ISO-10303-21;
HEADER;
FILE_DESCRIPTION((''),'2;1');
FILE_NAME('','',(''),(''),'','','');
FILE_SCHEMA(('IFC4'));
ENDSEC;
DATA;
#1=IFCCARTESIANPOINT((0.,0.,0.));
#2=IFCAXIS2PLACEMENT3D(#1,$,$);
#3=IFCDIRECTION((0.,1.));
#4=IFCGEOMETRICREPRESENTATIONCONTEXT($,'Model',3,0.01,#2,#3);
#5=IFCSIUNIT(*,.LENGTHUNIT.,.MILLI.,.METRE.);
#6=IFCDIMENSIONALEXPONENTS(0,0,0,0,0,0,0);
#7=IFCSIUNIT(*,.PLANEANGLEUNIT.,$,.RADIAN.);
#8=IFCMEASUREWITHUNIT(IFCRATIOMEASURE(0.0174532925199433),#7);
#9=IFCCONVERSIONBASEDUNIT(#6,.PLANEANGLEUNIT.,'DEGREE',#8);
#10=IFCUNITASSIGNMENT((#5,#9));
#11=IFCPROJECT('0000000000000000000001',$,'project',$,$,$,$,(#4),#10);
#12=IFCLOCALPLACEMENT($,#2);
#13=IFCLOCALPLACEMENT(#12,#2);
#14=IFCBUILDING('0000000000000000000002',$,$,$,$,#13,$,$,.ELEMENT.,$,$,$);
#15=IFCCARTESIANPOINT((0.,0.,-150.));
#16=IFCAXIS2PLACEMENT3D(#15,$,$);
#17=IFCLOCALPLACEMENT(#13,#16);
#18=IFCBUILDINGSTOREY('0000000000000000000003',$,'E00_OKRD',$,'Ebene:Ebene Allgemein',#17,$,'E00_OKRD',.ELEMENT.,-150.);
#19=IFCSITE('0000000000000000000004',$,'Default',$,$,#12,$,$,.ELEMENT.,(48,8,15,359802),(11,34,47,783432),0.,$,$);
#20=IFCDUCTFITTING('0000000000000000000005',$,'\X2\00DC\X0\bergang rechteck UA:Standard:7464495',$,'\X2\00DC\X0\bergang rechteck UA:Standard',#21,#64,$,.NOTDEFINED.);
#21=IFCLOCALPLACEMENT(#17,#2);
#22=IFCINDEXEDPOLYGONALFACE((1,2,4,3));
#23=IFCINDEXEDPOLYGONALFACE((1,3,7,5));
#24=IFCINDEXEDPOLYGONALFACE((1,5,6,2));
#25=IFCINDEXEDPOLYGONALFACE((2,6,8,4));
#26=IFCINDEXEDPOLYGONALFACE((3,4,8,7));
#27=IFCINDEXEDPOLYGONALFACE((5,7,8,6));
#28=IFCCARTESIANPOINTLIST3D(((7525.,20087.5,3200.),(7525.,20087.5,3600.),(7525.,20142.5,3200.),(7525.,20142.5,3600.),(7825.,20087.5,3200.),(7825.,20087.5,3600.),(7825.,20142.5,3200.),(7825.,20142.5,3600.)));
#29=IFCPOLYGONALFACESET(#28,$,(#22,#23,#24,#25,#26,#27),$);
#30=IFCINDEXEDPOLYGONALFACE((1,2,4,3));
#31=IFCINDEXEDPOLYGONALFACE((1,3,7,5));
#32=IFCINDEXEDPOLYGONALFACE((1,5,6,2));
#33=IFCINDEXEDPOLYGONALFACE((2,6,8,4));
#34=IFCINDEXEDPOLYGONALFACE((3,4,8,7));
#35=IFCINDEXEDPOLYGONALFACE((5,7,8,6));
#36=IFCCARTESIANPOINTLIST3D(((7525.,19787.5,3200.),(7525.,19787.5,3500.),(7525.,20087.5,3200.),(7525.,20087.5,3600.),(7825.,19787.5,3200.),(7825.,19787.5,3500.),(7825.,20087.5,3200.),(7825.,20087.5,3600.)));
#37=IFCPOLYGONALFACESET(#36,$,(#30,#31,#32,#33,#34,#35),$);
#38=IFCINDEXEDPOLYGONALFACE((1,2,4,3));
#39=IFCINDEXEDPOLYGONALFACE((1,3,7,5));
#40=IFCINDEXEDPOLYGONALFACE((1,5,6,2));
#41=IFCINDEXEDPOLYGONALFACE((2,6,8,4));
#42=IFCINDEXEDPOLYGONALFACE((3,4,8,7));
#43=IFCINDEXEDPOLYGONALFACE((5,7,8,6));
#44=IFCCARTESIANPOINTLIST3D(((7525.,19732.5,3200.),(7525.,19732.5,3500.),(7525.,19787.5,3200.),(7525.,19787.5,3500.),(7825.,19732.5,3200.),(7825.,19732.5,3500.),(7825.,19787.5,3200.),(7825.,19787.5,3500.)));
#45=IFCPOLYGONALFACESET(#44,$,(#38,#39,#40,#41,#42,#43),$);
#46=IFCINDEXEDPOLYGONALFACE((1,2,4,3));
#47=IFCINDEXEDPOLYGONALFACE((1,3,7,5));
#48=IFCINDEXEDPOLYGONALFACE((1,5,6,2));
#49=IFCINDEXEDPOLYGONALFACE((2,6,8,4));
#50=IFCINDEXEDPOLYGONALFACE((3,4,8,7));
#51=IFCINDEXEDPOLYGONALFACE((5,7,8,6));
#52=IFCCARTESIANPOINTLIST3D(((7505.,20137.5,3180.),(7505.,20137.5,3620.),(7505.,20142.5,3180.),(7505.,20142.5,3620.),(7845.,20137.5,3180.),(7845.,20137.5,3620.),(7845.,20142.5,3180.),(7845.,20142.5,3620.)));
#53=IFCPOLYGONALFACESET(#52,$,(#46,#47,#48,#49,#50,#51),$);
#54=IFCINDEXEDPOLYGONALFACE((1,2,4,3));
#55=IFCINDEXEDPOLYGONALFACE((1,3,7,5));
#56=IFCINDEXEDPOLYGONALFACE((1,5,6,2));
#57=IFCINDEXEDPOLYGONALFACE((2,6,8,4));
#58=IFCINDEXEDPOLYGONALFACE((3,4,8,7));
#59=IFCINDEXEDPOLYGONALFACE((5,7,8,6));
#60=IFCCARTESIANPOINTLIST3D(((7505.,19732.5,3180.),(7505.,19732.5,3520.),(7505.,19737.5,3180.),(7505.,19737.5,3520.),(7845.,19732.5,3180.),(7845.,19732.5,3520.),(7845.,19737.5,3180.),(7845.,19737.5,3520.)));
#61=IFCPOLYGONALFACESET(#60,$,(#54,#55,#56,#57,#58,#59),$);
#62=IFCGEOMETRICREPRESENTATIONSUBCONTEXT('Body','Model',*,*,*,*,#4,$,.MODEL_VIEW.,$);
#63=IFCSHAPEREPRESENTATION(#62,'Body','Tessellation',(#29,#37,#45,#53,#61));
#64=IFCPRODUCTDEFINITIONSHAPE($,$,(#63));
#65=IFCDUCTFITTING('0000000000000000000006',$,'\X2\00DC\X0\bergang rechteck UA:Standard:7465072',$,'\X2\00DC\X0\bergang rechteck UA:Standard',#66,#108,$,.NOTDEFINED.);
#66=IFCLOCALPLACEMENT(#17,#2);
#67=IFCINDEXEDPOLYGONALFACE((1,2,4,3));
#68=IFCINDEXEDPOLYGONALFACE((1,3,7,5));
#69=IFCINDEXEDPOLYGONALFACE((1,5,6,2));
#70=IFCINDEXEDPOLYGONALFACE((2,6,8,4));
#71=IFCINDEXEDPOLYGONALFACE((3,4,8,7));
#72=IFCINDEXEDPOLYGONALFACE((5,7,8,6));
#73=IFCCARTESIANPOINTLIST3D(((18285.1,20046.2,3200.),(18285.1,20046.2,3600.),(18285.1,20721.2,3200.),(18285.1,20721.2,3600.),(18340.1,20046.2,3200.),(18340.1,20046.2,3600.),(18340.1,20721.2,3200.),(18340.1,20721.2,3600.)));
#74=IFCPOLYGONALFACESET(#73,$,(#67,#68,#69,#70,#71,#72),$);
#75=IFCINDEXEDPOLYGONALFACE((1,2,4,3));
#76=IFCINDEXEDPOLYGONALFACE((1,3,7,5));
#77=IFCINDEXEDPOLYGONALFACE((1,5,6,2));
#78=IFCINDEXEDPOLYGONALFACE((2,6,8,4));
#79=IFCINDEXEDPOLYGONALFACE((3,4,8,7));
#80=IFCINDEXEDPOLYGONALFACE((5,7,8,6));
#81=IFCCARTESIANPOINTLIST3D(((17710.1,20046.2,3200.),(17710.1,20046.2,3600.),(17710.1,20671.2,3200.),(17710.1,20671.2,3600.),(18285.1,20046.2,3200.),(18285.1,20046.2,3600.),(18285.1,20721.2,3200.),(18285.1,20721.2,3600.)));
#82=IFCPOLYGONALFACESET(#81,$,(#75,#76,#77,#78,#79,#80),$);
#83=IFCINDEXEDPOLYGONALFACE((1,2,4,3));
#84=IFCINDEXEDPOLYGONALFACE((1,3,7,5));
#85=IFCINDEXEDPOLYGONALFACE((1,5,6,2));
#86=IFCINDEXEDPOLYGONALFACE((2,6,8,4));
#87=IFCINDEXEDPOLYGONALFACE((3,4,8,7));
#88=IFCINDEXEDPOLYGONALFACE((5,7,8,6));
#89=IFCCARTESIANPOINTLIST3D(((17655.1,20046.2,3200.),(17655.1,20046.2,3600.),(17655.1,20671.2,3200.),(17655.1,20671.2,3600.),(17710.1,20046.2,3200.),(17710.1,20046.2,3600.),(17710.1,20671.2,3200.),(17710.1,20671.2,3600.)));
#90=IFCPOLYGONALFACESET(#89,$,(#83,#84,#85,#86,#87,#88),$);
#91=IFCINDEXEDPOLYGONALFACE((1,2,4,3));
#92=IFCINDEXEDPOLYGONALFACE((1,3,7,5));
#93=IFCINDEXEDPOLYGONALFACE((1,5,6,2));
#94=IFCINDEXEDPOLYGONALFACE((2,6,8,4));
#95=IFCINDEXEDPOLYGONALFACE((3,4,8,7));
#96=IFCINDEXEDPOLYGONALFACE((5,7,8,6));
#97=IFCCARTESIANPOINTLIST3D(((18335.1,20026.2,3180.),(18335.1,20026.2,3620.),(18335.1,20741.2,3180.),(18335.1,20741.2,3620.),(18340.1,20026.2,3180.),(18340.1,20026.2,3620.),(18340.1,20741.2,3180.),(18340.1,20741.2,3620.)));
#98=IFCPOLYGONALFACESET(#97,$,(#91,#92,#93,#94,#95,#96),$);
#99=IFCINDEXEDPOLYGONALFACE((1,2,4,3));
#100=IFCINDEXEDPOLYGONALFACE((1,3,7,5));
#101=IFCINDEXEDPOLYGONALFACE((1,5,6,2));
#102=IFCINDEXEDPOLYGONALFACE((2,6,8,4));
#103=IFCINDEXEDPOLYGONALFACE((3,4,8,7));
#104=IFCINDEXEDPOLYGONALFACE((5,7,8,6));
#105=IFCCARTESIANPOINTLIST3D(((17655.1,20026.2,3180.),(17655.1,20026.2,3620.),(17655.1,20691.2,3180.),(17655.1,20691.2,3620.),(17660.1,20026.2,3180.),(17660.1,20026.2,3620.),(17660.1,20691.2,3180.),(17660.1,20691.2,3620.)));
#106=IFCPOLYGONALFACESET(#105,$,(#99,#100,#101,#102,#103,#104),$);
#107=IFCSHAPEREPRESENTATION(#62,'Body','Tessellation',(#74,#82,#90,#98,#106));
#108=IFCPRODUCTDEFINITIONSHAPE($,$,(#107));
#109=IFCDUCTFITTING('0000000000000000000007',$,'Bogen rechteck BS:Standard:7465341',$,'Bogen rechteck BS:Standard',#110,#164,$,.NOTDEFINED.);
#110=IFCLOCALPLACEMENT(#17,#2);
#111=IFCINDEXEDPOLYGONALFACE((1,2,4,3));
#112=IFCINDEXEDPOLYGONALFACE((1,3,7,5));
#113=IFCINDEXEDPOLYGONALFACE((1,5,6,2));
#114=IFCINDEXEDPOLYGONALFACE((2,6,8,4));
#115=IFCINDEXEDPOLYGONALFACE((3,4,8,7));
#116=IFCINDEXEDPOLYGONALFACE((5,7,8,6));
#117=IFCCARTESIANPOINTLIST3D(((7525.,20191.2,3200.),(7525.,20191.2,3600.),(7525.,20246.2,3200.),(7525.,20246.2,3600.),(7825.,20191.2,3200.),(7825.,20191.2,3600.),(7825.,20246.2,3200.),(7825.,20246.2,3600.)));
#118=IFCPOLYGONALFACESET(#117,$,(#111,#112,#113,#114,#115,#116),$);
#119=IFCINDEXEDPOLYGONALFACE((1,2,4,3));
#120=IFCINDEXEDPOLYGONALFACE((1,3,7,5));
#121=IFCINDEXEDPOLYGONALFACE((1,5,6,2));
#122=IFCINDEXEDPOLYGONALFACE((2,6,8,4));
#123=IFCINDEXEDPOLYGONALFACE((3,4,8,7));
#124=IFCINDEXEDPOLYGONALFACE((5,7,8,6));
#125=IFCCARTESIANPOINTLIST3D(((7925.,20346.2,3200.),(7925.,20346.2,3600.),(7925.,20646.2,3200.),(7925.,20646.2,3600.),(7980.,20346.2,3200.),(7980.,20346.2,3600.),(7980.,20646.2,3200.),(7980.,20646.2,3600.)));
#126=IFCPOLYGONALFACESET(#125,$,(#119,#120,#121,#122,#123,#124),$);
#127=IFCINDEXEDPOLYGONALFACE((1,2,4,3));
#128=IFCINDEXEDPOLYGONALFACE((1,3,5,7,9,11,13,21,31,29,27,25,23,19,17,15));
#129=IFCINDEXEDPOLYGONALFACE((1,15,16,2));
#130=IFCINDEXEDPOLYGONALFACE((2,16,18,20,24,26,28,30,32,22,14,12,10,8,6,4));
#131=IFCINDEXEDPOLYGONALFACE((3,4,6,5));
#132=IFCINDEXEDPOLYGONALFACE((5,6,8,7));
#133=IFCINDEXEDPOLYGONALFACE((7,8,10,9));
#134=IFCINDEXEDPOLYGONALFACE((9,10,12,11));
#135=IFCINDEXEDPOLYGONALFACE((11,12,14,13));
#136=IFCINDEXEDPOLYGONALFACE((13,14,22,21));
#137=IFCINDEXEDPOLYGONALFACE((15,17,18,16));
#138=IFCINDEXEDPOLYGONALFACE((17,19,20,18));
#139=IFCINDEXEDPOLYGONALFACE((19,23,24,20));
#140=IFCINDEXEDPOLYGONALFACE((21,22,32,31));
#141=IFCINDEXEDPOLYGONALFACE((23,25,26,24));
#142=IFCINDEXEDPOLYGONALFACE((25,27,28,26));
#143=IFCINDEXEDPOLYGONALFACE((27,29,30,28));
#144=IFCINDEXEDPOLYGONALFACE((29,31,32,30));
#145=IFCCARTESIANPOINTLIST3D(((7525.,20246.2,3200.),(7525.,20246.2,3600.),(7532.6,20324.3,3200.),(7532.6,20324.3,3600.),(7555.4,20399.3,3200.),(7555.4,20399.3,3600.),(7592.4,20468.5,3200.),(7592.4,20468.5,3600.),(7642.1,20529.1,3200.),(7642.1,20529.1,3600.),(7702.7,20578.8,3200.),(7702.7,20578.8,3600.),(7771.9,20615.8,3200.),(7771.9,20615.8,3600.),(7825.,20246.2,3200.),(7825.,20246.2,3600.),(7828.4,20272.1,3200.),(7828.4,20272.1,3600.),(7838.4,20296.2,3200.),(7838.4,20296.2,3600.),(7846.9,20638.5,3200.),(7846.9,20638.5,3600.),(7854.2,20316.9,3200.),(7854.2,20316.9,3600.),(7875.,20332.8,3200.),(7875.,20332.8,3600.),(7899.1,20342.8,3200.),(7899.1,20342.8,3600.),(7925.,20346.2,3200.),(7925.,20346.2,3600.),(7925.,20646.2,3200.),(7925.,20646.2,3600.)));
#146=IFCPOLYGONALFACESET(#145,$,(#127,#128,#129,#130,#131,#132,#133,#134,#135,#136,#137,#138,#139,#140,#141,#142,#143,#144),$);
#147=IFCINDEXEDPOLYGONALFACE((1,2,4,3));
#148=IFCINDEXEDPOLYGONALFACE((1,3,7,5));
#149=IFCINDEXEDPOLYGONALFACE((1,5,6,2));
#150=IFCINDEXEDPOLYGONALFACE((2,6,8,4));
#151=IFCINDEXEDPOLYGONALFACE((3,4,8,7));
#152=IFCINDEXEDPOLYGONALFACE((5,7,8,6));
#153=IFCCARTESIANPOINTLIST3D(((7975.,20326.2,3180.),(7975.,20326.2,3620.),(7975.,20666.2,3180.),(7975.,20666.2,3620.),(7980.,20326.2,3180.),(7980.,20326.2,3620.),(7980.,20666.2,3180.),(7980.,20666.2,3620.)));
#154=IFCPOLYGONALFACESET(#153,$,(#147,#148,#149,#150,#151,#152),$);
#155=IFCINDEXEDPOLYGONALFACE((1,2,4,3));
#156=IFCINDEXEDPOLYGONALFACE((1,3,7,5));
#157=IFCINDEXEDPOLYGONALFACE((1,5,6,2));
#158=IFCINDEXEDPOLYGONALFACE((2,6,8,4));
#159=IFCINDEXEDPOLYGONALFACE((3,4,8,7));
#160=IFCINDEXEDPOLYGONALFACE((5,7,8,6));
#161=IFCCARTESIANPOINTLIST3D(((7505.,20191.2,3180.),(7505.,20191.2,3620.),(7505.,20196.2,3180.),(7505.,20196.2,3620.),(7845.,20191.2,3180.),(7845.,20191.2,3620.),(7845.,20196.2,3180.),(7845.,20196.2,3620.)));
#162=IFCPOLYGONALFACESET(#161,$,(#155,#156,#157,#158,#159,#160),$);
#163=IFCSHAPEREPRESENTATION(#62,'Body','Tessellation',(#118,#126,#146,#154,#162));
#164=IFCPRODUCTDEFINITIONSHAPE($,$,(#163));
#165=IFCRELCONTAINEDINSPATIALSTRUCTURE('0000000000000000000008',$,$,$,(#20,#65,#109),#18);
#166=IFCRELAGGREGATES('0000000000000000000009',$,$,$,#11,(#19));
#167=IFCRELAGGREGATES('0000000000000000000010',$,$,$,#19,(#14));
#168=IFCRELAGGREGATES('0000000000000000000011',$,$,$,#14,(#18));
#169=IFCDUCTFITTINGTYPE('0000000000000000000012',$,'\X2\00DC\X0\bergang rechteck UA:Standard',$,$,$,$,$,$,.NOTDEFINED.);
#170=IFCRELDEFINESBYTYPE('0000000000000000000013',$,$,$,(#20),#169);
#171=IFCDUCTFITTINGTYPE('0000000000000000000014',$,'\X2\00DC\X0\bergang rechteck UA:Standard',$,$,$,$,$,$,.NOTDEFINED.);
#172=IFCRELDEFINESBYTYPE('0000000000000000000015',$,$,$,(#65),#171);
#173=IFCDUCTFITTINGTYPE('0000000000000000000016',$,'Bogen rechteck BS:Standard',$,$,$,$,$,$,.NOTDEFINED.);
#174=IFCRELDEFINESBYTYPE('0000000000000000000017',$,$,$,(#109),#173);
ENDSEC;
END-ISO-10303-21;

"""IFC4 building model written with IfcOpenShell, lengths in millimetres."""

from ifc_helpers import new_model, entity, si_unit, converted_unit, direction, frame, frame_2d, origin, origin_2d_with_axis, place, context, subcontext, project, spatial, polyline, circle_curve, parameter, trimmed, segment, composite_curve, rectangle, outline, extrude, source, transform, mapped, type_object, type_shapes, element, save


model = new_model("IFC4")

# Units and contexts
model_context = context("Model", 3, precision=0.01, world=origin(), true_north=direction((0.0, 1.0)))
body_context = subcontext(model_context, "Body", "Model", "MODEL_VIEW")
ifc_project = project(units=[si_unit("LENGTHUNIT", "METRE", prefix="MILLI"), converted_unit("PLANEANGLEUNIT", "DEGREE", entity("IfcRatioMeasure", 0.0174532925199433), si_unit("PLANEANGLEUNIT", "RADIAN"), dimensions=[0, 0, 0, 0, 0, 0, 0])], contexts=[model_context])

# Site, building, storey
site_placement = place(None, origin())
site = spatial("IfcSite", under=ifc_project, at=site_placement, Name="Default", CompositionType="ELEMENT", RefLatitude=(48, 8, 15, 359802), RefLongitude=(11, 34, 47, 783432), RefElevation=0.0)
building_placement = place(site_placement, origin())
building = spatial("IfcBuilding", under=site, at=building_placement, CompositionType="ELEMENT")
storey_placement = place(building_placement, frame((0.0, 0.0, -150.0)))
storey = spatial("IfcBuildingStorey", under=building, at=storey_placement, Name="E00_OKRD", ObjectType="Ebene:Ebene Allgemein", LongName="E00_OKRD", CompositionType="ELEMENT", Elevation=-150.0)

# Duct fittings
duct_fitting_type_1 = type_object("IfcDuctFittingType", Name="Übergang rechteck UA:Standard", PredefinedType="NOTDEFINED")
shared_shape_1 = source(origin(), body_context, "Body", "SweptSolid", [
    extrude(rectangle(XDim=55.0, YDim=300.0, at=origin_2d_with_axis()), frame((382.5, 0.0, -150.0)), (0.0, 0.0, 1.0), 400.0),
    extrude(outline(polyline([(-102.8, -166.0), (213.5, -166.0), (87.0, 213.5), (-197.6, 118.6), (-102.8, -166.0)])), frame((205.0, -150.0, 25.0), z_axis=(0.0, 1.0, 0.0), x_axis=(0.948683, 0.0, 0.316228)), (0.0, 0.0, 1.0), 300.0),
    extrude(rectangle(XDim=55.0, YDim=300.0, at=frame_2d((0.0, 0.0), x_axis=(1.0, 0.0))), frame((27.5, 0.0, -150.0)), (0.0, 0.0, 1.0), 300.0),
    extrude(rectangle(XDim=5.0, YDim=340.0, at=frame_2d((0.0, 0.0), x_axis=(1.0, 0.0))), frame((407.5, 0.0, -170.0)), (0.0, 0.0, 1.0), 440.0),
    extrude(rectangle(XDim=5.0, YDim=340.0, at=frame_2d((0.0, 0.0), x_axis=(1.0, 0.0))), frame((2.5, 0.0, -170.0)), (0.0, 0.0, 1.0), 340.0),
])
type_shapes(duct_fitting_type_1, [shared_shape_1])
duct_fitting_1_placement = place(storey_placement, frame((7675.0, 19732.5, 3350.0), z_axis=(0.0, 0.0, 1.0), x_axis=(0.0, 1.0, 0.0)))
element("IfcDuctFitting", 1, at=duct_fitting_1_placement, inside=storey, type_object=duct_fitting_type_1, Name="Übergang rechteck UA:Standard:7464495", ObjectType="Übergang rechteck UA:Standard", PredefinedType="NOTDEFINED", context=body_context, shape_type="MappedRepresentation", body=[
    mapped(shared_shape_1, transform((0.0, 0.0, 0.0), scale=1.0)),
])
duct_fitting_type_2 = type_object("IfcDuctFittingType", Name="Übergang rechteck UA:Standard", PredefinedType="NOTDEFINED")
shared_shape_2 = source(origin(), body_context, "Body", "SweptSolid", [
    extrude(rectangle(XDim=55.0, YDim=675.0, at=frame_2d((0.0, 0.0), x_axis=(1.0, 0.0))), frame((657.5, 25.0, -200.0)), (0.0, 0.0, 1.0), 400.0),
    extrude(outline(polyline([(-287.5, -325.0), (287.5, -325.0), (287.5, 350.0), (-287.5, 300.0), (-287.5, -325.0)])), frame((342.5, 12.5, -200.0)), (0.0, 0.0, 1.0), 400.0),
    extrude(rectangle(XDim=55.0, YDim=625.0, at=frame_2d((0.0, 0.0), x_axis=(1.0, 0.0))), frame((27.5, 0.0, -200.0)), (0.0, 0.0, 1.0), 400.0),
    extrude(rectangle(XDim=5.0, YDim=715.0, at=origin_2d_with_axis()), frame((682.5, 25.0, -220.0)), (0.0, 0.0, 1.0), 440.0),
    extrude(rectangle(XDim=5.0, YDim=665.0, at=frame_2d((0.0, 0.0), x_axis=(1.0, 0.0))), frame((2.5, 0.0, -220.0)), (0.0, 0.0, 1.0), 440.0),
])
type_shapes(duct_fitting_type_2, [shared_shape_2])
duct_fitting_2_placement = place(storey_placement, frame((17655.1, 20358.7, 3400.0)))
element("IfcDuctFitting", 2, at=duct_fitting_2_placement, inside=storey, type_object=duct_fitting_type_2, Name="Übergang rechteck UA:Standard:7465072", ObjectType="Übergang rechteck UA:Standard", PredefinedType="NOTDEFINED", context=body_context, shape_type="MappedRepresentation", body=[
    mapped(shared_shape_2, transform((0.0, 0.0, 0.0), scale=1.0)),
])
duct_fitting_type_3 = type_object("IfcDuctFittingType", Name="Bogen rechteck BS:Standard", PredefinedType="NOTDEFINED")
shared_shape_3 = source(origin(), body_context, "Body", "SweptSolid", [
    extrude(rectangle(XDim=55.0, YDim=300.0, at=origin_2d_with_axis()), frame((0.0, 277.5, -200.0), z_axis=(0.0, 0.0, 1.0), x_axis=(0.0, 1.0, 0.0)), (0.0, 0.0, 1.0), 400.0),
    extrude(rectangle(XDim=300.0, YDim=55.0, at=frame_2d((0.0, 0.0), x_axis=(1.0, 0.0))), frame((-277.5, 0.0, -200.0), z_axis=(0.0, 0.0, 1.0), x_axis=(0.0, -1.0, 0.0)), (0.0, 0.0, 1.0), 400.0),
    extrude(outline(composite_curve([segment(polyline([(-275.0, -125.0), (25.0, -125.0)]), True, "CONTINUOUS"), segment(trimmed(circle_curve(frame_2d((125.0, -125.0), x_axis=(0.0, 1.0)), 100.0), [parameter(0.0)], [parameter(90.0)], True, "PARAMETER"), False, "CONTINUOUS"), segment(polyline([(125.0, -25.0), (125.0, 275.0)]), True, "CONTINUOUS"), segment(trimmed(circle_curve(frame_2d((125.0, -125.0), x_axis=(0.0, 1.0)), 400.0), [parameter(0.0)], [parameter(90.0)], True, "PARAMETER"), True, "CONTINUOUS")], self_intersect=False)), frame((-125.0, 125.0, -200.0), z_axis=(0.0, 0.0, 1.0), x_axis=(-1.0, 0.0, 0.0)), (0.0, 0.0, 1.0), 400.0),
    extrude(rectangle(XDim=5.0, YDim=340.0, at=frame_2d((0.0, 0.0), x_axis=(1.0, 0.0))), frame((-302.5, 0.0, -220.0)), (0.0, 0.0, 1.0), 440.0),
    extrude(rectangle(XDim=5.0, YDim=340.0, at=origin_2d_with_axis()), frame((0.0, 302.5, -220.0), z_axis=(0.0, 0.0, 1.0), x_axis=(0.0, 1.0, 0.0)), (0.0, 0.0, 1.0), 440.0),
])
type_shapes(duct_fitting_type_3, [shared_shape_3])
duct_fitting_3_placement = place(storey_placement, frame((7675.0, 20496.2, 3400.0), z_axis=(0.0, 0.0, 1.0), x_axis=(-1.0, 0.0, 0.0)))
element("IfcDuctFitting", 3, at=duct_fitting_3_placement, inside=storey, type_object=duct_fitting_type_3, Name="Bogen rechteck BS:Standard:7465341", ObjectType="Bogen rechteck BS:Standard", PredefinedType="NOTDEFINED", context=body_context, shape_type="MappedRepresentation", body=[
    mapped(shared_shape_3, transform((0.0, 0.0, 0.0), scale=1.0)),
])

save(model, "model.ifc")
